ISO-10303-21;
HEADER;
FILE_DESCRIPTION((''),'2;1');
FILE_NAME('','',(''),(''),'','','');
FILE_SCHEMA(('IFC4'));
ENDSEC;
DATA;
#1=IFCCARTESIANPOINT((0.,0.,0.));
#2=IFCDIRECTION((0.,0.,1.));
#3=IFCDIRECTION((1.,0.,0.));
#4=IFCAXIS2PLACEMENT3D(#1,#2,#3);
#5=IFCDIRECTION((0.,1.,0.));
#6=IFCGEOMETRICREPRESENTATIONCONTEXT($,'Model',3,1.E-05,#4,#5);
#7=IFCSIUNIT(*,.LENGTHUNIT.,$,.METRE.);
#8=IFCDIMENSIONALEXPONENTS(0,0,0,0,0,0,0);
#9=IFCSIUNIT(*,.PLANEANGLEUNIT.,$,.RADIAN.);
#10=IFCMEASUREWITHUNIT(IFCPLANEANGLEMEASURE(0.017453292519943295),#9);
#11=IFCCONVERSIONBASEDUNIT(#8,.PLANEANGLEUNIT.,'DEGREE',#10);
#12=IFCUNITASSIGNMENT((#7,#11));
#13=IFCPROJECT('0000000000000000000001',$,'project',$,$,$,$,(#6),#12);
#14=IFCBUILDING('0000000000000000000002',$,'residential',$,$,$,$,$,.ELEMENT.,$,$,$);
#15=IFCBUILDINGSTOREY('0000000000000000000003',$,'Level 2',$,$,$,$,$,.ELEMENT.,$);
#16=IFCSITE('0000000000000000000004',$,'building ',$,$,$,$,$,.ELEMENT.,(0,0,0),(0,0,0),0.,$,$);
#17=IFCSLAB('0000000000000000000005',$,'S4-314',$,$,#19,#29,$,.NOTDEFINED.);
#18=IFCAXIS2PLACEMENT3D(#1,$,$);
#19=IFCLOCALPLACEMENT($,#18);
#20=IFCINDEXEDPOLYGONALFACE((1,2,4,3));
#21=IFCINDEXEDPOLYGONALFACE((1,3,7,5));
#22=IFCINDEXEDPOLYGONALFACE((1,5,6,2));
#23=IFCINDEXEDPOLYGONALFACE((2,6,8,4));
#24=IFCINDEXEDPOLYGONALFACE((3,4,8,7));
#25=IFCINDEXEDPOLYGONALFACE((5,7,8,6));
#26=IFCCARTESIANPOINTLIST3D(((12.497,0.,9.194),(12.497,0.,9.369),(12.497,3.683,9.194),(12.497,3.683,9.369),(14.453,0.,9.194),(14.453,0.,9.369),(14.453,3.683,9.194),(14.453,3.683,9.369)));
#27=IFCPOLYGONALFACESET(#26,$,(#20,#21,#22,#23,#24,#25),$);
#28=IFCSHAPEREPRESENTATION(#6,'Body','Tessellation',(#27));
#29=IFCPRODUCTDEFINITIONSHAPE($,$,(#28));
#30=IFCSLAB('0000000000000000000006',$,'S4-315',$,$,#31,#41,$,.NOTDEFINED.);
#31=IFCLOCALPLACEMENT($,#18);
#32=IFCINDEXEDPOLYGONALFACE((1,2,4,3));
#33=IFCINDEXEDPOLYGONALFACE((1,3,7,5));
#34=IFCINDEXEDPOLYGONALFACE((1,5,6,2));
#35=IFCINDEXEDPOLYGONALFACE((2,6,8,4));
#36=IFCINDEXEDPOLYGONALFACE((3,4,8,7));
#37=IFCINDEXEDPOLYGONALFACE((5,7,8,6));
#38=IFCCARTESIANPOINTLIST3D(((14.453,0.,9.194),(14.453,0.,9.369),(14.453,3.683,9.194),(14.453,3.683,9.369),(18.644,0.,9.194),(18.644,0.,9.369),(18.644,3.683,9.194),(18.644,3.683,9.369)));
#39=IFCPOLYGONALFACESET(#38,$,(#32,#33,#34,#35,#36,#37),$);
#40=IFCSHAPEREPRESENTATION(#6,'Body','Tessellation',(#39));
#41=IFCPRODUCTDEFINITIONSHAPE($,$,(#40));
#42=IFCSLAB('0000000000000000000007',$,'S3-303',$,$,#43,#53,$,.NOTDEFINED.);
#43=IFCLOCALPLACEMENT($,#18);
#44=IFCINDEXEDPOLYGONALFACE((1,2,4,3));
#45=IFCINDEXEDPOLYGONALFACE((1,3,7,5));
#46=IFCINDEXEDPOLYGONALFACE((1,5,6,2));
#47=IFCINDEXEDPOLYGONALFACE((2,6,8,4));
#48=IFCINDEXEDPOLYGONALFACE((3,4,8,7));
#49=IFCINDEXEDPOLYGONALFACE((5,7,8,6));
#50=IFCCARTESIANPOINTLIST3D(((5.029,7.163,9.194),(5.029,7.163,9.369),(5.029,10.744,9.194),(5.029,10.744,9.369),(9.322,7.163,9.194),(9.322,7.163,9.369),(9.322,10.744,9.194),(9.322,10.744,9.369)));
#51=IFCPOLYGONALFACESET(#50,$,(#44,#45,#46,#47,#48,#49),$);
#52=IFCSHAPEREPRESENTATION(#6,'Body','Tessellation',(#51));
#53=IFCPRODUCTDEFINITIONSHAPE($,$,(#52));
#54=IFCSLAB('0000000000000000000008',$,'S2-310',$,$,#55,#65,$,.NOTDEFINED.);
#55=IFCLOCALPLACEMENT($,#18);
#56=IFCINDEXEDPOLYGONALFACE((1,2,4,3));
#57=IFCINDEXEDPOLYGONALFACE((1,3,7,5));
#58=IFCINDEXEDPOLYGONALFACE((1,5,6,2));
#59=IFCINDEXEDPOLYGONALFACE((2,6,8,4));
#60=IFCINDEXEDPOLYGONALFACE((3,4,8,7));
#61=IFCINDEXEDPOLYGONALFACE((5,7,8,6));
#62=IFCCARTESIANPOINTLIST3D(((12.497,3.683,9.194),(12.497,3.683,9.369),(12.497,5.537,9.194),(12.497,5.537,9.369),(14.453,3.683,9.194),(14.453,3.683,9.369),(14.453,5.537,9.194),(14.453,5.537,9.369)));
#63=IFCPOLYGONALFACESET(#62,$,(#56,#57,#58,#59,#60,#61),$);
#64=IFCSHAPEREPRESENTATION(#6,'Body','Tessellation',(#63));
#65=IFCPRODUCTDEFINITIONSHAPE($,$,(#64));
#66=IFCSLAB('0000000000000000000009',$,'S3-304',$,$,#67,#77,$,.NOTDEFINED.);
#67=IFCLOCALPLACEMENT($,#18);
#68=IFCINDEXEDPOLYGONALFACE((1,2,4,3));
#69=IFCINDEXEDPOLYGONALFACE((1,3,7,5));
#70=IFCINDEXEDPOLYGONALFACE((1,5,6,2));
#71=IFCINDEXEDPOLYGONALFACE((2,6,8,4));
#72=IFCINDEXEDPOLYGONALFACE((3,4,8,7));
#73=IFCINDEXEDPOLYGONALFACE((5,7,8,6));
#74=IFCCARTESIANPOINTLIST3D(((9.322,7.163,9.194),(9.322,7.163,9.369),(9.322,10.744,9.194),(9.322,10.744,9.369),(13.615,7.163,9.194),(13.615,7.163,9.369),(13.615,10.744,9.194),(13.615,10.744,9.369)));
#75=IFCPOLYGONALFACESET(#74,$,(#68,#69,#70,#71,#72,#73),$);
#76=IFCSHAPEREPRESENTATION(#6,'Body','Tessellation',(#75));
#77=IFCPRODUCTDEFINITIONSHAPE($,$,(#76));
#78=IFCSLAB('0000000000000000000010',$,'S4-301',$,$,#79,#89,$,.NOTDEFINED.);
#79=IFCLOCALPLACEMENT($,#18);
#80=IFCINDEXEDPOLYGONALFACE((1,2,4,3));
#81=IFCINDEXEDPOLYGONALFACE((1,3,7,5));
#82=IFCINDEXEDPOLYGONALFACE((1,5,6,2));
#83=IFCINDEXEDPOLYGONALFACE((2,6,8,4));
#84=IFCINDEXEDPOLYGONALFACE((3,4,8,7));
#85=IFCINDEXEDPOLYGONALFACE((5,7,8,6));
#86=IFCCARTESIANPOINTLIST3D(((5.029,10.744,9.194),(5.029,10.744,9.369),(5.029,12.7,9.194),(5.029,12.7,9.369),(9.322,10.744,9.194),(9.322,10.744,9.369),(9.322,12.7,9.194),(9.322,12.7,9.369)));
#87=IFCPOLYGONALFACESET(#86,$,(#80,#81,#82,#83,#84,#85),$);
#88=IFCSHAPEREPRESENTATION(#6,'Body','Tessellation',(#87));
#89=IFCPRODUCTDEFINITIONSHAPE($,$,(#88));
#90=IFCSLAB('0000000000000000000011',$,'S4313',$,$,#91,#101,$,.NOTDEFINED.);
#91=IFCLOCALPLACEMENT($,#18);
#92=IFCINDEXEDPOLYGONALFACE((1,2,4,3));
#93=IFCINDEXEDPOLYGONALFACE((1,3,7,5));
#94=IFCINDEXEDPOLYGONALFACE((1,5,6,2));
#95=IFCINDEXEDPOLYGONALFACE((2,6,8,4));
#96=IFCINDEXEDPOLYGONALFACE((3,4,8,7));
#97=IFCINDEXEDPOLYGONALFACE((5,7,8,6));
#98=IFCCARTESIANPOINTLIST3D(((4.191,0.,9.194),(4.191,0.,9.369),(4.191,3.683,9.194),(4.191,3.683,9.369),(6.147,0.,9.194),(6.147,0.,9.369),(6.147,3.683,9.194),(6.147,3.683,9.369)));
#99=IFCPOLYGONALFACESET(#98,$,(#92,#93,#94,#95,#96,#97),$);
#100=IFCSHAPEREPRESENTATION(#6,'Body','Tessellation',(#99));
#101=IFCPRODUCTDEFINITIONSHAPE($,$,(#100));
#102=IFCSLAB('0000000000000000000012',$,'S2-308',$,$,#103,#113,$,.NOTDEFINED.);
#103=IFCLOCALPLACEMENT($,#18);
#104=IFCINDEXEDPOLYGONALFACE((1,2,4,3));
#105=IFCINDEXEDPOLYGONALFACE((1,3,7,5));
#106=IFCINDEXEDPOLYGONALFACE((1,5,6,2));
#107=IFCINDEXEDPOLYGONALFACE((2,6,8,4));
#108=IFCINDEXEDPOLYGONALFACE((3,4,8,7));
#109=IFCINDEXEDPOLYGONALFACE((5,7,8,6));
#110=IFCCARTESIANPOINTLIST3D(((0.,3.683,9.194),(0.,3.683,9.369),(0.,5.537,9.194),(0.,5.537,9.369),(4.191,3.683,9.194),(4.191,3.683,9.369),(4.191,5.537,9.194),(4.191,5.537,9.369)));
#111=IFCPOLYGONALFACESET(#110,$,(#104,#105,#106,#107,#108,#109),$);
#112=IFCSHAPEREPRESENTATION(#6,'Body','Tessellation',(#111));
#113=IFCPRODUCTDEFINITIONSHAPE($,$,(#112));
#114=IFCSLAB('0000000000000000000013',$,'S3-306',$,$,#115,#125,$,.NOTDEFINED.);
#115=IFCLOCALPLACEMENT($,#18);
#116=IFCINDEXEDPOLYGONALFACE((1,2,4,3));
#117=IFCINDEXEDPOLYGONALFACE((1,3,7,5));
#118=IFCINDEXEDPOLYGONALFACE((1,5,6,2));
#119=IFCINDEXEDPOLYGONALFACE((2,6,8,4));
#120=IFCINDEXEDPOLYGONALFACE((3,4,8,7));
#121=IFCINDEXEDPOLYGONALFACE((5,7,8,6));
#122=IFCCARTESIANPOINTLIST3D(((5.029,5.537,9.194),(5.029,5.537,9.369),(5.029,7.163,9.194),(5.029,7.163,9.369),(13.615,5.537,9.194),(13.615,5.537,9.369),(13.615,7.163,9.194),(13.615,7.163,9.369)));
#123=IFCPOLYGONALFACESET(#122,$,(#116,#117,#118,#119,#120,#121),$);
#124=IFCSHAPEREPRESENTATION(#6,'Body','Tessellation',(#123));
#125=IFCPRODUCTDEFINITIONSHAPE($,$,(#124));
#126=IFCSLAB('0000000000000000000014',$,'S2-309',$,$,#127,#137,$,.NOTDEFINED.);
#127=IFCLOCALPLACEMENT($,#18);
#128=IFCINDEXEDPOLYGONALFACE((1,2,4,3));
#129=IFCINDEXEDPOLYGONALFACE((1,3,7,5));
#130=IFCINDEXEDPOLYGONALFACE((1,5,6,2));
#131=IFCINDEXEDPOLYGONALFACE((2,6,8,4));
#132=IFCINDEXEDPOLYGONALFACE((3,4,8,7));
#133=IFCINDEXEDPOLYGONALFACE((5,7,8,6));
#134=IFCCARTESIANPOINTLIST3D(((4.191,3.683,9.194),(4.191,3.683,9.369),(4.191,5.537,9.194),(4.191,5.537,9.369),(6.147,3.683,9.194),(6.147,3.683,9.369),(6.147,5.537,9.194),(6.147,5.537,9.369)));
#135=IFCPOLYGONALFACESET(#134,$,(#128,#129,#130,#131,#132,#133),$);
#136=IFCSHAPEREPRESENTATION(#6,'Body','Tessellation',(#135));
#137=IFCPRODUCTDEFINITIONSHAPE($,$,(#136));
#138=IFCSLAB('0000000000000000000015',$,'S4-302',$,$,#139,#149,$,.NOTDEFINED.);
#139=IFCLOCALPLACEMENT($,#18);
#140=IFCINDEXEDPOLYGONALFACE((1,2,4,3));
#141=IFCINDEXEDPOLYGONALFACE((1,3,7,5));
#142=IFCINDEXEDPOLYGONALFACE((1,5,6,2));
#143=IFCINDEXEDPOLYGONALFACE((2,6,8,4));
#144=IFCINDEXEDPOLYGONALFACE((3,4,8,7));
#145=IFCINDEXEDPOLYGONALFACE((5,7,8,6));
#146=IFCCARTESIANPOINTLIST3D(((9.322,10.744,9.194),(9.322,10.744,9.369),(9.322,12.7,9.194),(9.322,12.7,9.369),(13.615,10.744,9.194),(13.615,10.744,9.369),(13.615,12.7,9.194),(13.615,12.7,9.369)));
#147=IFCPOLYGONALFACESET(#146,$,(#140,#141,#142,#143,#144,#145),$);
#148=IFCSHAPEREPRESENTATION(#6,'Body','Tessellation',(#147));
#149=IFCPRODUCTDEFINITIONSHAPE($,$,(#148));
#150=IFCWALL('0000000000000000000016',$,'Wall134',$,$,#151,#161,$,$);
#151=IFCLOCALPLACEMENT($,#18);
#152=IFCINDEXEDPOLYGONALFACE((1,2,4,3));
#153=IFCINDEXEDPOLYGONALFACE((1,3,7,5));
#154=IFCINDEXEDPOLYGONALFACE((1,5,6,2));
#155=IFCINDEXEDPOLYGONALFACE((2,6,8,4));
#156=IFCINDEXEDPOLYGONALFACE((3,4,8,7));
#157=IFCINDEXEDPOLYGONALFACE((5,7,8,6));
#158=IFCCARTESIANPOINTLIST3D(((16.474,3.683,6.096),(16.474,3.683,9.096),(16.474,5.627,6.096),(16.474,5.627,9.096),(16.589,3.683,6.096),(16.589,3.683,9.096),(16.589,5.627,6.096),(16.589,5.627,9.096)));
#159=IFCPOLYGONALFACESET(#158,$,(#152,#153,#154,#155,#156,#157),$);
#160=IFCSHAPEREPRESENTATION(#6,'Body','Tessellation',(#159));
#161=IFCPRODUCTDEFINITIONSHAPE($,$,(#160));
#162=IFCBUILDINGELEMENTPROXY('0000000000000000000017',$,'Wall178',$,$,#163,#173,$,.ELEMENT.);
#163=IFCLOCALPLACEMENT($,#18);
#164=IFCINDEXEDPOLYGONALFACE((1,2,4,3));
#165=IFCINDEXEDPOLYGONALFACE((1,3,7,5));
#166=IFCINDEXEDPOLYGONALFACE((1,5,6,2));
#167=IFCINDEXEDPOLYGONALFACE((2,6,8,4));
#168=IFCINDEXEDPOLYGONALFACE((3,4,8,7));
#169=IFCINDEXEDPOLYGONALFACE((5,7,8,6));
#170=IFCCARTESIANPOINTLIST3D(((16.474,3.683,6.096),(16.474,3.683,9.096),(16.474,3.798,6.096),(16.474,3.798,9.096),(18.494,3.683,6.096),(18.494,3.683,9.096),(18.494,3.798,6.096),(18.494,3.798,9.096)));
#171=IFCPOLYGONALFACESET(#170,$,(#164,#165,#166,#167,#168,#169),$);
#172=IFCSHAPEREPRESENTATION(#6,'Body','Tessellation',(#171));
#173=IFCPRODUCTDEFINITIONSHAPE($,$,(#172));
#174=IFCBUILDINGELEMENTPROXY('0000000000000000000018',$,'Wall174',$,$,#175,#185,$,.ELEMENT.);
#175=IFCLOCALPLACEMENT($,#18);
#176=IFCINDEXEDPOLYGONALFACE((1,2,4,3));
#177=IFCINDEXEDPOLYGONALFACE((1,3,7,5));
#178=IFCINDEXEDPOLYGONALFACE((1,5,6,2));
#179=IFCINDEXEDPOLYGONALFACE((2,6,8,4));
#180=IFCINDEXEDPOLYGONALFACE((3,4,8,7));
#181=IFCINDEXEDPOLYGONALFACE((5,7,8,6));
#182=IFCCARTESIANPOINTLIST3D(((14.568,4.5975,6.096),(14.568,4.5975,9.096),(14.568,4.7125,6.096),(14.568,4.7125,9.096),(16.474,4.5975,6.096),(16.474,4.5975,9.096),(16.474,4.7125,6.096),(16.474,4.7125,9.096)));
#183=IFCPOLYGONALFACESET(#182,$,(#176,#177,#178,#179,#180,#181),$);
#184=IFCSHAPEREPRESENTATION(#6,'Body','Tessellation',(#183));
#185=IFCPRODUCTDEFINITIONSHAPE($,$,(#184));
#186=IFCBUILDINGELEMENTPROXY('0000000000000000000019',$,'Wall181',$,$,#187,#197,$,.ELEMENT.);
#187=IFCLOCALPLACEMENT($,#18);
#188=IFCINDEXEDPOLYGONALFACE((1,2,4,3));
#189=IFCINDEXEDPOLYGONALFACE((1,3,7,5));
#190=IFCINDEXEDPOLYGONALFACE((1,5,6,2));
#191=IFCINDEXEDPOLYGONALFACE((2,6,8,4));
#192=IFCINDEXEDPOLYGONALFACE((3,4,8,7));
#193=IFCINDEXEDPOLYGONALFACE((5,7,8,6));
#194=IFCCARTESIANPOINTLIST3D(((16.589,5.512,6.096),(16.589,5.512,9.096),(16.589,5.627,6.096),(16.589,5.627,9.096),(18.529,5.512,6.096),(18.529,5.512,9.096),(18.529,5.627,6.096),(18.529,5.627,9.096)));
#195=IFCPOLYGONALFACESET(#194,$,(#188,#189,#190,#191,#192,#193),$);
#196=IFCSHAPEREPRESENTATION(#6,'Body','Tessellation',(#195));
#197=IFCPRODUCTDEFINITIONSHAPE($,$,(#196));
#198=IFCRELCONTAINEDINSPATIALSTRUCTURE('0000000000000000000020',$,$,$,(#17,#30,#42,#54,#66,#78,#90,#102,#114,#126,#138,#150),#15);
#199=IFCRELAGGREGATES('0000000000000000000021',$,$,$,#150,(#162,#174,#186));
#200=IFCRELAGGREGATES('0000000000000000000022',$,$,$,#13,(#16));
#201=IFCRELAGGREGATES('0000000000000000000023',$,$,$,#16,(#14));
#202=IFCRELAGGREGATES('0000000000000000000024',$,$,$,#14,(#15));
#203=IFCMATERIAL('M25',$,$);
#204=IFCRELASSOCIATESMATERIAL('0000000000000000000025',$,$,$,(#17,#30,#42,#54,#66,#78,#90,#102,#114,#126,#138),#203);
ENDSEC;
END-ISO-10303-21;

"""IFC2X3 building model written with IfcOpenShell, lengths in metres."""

from ifc_helpers import new_model, entity, si_unit, converted_unit, direction, frame, frame_2d, origin_with_axes, place, context, project, spatial, rectangle, extrude, material, element, aggregate, save


model = new_model("IFC2X3")

# Units and contexts
model_context = context("Model", 3, precision=1e-05, world=origin_with_axes(), true_north=direction((0.0, 1.0, 0.0)))
ifc_project = project(units=[si_unit("LENGTHUNIT", "METRE"), converted_unit("PLANEANGLEUNIT", "DEGREE", entity("IfcPlaneAngleMeasure", 0.017453292519943295), si_unit("PLANEANGLEUNIT", "RADIAN"), dimensions=[0, 0, 0, 0, 0, 0, 0])], contexts=[model_context])

# Site, building, storey
site = spatial("IfcSite", under=ifc_project, Name="building ", CompositionType="ELEMENT", RefLatitude=(0, 0, 0), RefLongitude=(0, 0, 0), RefElevation=0.0)
building = spatial("IfcBuilding", under=site, Name="residential", CompositionType="ELEMENT")
storey = spatial("IfcBuildingStorey", under=building, Name="Level 2", CompositionType="ELEMENT")

# Slabs
ifc_material = material(Name="M25")
placement = place(None, origin_with_axes())
element("IfcSlab", 1, at=placement, inside=storey, material=ifc_material, Name="S4-314", PredefinedType="NOTDEFINED", context=model_context, shape_type="SweptSolid", body=[
    extrude(rectangle(XDim=1.956, YDim=3.683, at=frame_2d((0.0, 0.0), x_axis=(1.0, 0.0, 0.0))), frame((13.475, 1.8415, 9.194), z_axis=(0.0, 0.0, 1.0), x_axis=(1.0, 0.0, 0.0)), (0.0, 0.0, 1.0), 0.175),
])
element("IfcSlab", 2, at=placement, inside=storey, material=ifc_material, Name="S4-315", PredefinedType="NOTDEFINED", context=model_context, shape_type="SweptSolid", body=[
    extrude(rectangle(XDim=4.191, YDim=3.683, at=frame_2d((0.0, 0.0), x_axis=(1.0, 0.0, 0.0))), frame((16.5485, 1.8415, 9.194), z_axis=(0.0, 0.0, 1.0), x_axis=(1.0, 0.0, 0.0)), (0.0, 0.0, 1.0), 0.175),
])
element("IfcSlab", 3, at=placement, inside=storey, material=ifc_material, Name="S3-303", PredefinedType="NOTDEFINED", context=model_context, shape_type="SweptSolid", body=[
    extrude(rectangle(XDim=4.293, YDim=3.581, at=frame_2d((0.0, 0.0), x_axis=(1.0, 0.0, 0.0))), frame((7.1755, 8.9535, 9.194), z_axis=(0.0, 0.0, 1.0), x_axis=(1.0, 0.0, 0.0)), (0.0, 0.0, 1.0), 0.175),
])
element("IfcSlab", 4, at=placement, inside=storey, material=ifc_material, Name="S2-310", PredefinedType="NOTDEFINED", context=model_context, shape_type="SweptSolid", body=[
    extrude(rectangle(XDim=1.956, YDim=1.854, at=frame_2d((0.0, 0.0), x_axis=(1.0, 0.0, 0.0))), frame((13.475, 4.61, 9.194), z_axis=(0.0, 0.0, 1.0), x_axis=(1.0, 0.0, 0.0)), (0.0, 0.0, 1.0), 0.175),
])
element("IfcSlab", 5, at=placement, inside=storey, material=ifc_material, Name="S3-304", PredefinedType="NOTDEFINED", context=model_context, shape_type="SweptSolid", body=[
    extrude(rectangle(XDim=4.293, YDim=3.581, at=frame_2d((0.0, 0.0), x_axis=(1.0, 0.0, 0.0))), frame((11.4685, 8.9535, 9.194), z_axis=(0.0, 0.0, 1.0), x_axis=(1.0, 0.0, 0.0)), (0.0, 0.0, 1.0), 0.175),
])
element("IfcSlab", 6, at=placement, inside=storey, material=ifc_material, Name="S4-301", PredefinedType="NOTDEFINED", context=model_context, shape_type="SweptSolid", body=[
    extrude(rectangle(XDim=4.293, YDim=1.956, at=frame_2d((0.0, 0.0), x_axis=(1.0, 0.0, 0.0))), frame((7.1755, 11.722, 9.194), z_axis=(0.0, 0.0, 1.0), x_axis=(1.0, 0.0, 0.0)), (0.0, 0.0, 1.0), 0.175),
])
element("IfcSlab", 7, at=placement, inside=storey, material=ifc_material, Name="S4313", PredefinedType="NOTDEFINED", context=model_context, shape_type="SweptSolid", body=[
    extrude(rectangle(XDim=1.956, YDim=3.683, at=frame_2d((0.0, 0.0), x_axis=(1.0, 0.0, 0.0))), frame((5.169, 1.8415, 9.194), z_axis=(0.0, 0.0, 1.0), x_axis=(1.0, 0.0, 0.0)), (0.0, 0.0, 1.0), 0.175),
])
element("IfcSlab", 8, at=placement, inside=storey, material=ifc_material, Name="S2-308", PredefinedType="NOTDEFINED", context=model_context, shape_type="SweptSolid", body=[
    extrude(rectangle(XDim=4.191, YDim=1.854, at=frame_2d((0.0, 0.0), x_axis=(1.0, 0.0, 0.0))), frame((2.0955, 4.61, 9.194), z_axis=(0.0, 0.0, 1.0), x_axis=(1.0, 0.0, 0.0)), (0.0, 0.0, 1.0), 0.175),
])
element("IfcSlab", 9, at=placement, inside=storey, material=ifc_material, Name="S3-306", PredefinedType="NOTDEFINED", context=model_context, shape_type="SweptSolid", body=[
    extrude(rectangle(XDim=8.586, YDim=1.626, at=frame_2d((0.0, 0.0), x_axis=(1.0, 0.0, 0.0))), frame((9.322, 6.35, 9.194), z_axis=(0.0, 0.0, 1.0), x_axis=(1.0, 0.0, 0.0)), (0.0, 0.0, 1.0), 0.175),
])
element("IfcSlab", 10, at=placement, inside=storey, material=ifc_material, Name="S2-309", PredefinedType="NOTDEFINED", context=model_context, shape_type="SweptSolid", body=[
    extrude(rectangle(XDim=1.956, YDim=1.854, at=frame_2d((0.0, 0.0), x_axis=(1.0, 0.0, 0.0))), frame((5.169, 4.61, 9.194), z_axis=(0.0, 0.0, 1.0), x_axis=(1.0, 0.0, 0.0)), (0.0, 0.0, 1.0), 0.175),
])
element("IfcSlab", 11, at=placement, inside=storey, material=ifc_material, Name="S4-302", PredefinedType="NOTDEFINED", context=model_context, shape_type="SweptSolid", body=[
    extrude(rectangle(XDim=4.293, YDim=1.956, at=frame_2d((0.0, 0.0), x_axis=(1.0, 0.0, 0.0))), frame((11.4685, 11.722, 9.194), z_axis=(0.0, 0.0, 1.0), x_axis=(1.0, 0.0, 0.0)), (0.0, 0.0, 1.0), 0.175),
])

# Wall
wall_1 = element("IfcWall", 12, at=placement, inside=storey, Name="Wall134", context=model_context, shape_type="SweptSolid", body=[
    extrude(rectangle(XDim=1.944, YDim=0.115, at=frame_2d((0.0, 0.0), x_axis=(0.0, 1.0, 0.0))), frame((16.5315, 4.655, 6.096), z_axis=(0.0, 0.0, 1.0), x_axis=(1.0, 0.0, 0.0)), (0.0, 0.0, 1.0), 3.0),
])

# Building element proxies
proxy_1 = element("IfcBuildingElementProxy", 13, at=placement, Name="Wall178", CompositionType="ELEMENT", context=model_context, shape_type="SweptSolid", body=[
    extrude(rectangle(XDim=2.02, YDim=0.115, at=frame_2d((0.0, 0.0), x_axis=(1.0, 0.0, 0.0))), frame((17.484, 3.7405, 6.096), z_axis=(0.0, 0.0, 1.0), x_axis=(1.0, 0.0, 0.0)), (0.0, 0.0, 1.0), 3.0),
])
proxy_2 = element("IfcBuildingElementProxy", 14, at=placement, Name="Wall174", CompositionType="ELEMENT", context=model_context, shape_type="SweptSolid", body=[
    extrude(rectangle(XDim=1.906, YDim=0.115, at=frame_2d((0.0, 0.0), x_axis=(-1.0, 0.0, 0.0))), frame((15.521, 4.655, 6.096), z_axis=(0.0, 0.0, 1.0), x_axis=(1.0, 0.0, 0.0)), (0.0, 0.0, 1.0), 3.0),
])
proxy_3 = element("IfcBuildingElementProxy", 15, at=placement, Name="Wall181", CompositionType="ELEMENT", context=model_context, shape_type="SweptSolid", body=[
    extrude(rectangle(XDim=1.94, YDim=0.115, at=frame_2d((0.0, 0.0), x_axis=(1.0, 0.0, 0.0))), frame((17.559, 5.5695, 6.096), z_axis=(0.0, 0.0, 1.0), x_axis=(1.0, 0.0, 0.0)), (0.0, 0.0, 1.0), 3.0),
])
aggregate(wall_1, [proxy_1, proxy_2, proxy_3])

save(model, "model.ifc")
